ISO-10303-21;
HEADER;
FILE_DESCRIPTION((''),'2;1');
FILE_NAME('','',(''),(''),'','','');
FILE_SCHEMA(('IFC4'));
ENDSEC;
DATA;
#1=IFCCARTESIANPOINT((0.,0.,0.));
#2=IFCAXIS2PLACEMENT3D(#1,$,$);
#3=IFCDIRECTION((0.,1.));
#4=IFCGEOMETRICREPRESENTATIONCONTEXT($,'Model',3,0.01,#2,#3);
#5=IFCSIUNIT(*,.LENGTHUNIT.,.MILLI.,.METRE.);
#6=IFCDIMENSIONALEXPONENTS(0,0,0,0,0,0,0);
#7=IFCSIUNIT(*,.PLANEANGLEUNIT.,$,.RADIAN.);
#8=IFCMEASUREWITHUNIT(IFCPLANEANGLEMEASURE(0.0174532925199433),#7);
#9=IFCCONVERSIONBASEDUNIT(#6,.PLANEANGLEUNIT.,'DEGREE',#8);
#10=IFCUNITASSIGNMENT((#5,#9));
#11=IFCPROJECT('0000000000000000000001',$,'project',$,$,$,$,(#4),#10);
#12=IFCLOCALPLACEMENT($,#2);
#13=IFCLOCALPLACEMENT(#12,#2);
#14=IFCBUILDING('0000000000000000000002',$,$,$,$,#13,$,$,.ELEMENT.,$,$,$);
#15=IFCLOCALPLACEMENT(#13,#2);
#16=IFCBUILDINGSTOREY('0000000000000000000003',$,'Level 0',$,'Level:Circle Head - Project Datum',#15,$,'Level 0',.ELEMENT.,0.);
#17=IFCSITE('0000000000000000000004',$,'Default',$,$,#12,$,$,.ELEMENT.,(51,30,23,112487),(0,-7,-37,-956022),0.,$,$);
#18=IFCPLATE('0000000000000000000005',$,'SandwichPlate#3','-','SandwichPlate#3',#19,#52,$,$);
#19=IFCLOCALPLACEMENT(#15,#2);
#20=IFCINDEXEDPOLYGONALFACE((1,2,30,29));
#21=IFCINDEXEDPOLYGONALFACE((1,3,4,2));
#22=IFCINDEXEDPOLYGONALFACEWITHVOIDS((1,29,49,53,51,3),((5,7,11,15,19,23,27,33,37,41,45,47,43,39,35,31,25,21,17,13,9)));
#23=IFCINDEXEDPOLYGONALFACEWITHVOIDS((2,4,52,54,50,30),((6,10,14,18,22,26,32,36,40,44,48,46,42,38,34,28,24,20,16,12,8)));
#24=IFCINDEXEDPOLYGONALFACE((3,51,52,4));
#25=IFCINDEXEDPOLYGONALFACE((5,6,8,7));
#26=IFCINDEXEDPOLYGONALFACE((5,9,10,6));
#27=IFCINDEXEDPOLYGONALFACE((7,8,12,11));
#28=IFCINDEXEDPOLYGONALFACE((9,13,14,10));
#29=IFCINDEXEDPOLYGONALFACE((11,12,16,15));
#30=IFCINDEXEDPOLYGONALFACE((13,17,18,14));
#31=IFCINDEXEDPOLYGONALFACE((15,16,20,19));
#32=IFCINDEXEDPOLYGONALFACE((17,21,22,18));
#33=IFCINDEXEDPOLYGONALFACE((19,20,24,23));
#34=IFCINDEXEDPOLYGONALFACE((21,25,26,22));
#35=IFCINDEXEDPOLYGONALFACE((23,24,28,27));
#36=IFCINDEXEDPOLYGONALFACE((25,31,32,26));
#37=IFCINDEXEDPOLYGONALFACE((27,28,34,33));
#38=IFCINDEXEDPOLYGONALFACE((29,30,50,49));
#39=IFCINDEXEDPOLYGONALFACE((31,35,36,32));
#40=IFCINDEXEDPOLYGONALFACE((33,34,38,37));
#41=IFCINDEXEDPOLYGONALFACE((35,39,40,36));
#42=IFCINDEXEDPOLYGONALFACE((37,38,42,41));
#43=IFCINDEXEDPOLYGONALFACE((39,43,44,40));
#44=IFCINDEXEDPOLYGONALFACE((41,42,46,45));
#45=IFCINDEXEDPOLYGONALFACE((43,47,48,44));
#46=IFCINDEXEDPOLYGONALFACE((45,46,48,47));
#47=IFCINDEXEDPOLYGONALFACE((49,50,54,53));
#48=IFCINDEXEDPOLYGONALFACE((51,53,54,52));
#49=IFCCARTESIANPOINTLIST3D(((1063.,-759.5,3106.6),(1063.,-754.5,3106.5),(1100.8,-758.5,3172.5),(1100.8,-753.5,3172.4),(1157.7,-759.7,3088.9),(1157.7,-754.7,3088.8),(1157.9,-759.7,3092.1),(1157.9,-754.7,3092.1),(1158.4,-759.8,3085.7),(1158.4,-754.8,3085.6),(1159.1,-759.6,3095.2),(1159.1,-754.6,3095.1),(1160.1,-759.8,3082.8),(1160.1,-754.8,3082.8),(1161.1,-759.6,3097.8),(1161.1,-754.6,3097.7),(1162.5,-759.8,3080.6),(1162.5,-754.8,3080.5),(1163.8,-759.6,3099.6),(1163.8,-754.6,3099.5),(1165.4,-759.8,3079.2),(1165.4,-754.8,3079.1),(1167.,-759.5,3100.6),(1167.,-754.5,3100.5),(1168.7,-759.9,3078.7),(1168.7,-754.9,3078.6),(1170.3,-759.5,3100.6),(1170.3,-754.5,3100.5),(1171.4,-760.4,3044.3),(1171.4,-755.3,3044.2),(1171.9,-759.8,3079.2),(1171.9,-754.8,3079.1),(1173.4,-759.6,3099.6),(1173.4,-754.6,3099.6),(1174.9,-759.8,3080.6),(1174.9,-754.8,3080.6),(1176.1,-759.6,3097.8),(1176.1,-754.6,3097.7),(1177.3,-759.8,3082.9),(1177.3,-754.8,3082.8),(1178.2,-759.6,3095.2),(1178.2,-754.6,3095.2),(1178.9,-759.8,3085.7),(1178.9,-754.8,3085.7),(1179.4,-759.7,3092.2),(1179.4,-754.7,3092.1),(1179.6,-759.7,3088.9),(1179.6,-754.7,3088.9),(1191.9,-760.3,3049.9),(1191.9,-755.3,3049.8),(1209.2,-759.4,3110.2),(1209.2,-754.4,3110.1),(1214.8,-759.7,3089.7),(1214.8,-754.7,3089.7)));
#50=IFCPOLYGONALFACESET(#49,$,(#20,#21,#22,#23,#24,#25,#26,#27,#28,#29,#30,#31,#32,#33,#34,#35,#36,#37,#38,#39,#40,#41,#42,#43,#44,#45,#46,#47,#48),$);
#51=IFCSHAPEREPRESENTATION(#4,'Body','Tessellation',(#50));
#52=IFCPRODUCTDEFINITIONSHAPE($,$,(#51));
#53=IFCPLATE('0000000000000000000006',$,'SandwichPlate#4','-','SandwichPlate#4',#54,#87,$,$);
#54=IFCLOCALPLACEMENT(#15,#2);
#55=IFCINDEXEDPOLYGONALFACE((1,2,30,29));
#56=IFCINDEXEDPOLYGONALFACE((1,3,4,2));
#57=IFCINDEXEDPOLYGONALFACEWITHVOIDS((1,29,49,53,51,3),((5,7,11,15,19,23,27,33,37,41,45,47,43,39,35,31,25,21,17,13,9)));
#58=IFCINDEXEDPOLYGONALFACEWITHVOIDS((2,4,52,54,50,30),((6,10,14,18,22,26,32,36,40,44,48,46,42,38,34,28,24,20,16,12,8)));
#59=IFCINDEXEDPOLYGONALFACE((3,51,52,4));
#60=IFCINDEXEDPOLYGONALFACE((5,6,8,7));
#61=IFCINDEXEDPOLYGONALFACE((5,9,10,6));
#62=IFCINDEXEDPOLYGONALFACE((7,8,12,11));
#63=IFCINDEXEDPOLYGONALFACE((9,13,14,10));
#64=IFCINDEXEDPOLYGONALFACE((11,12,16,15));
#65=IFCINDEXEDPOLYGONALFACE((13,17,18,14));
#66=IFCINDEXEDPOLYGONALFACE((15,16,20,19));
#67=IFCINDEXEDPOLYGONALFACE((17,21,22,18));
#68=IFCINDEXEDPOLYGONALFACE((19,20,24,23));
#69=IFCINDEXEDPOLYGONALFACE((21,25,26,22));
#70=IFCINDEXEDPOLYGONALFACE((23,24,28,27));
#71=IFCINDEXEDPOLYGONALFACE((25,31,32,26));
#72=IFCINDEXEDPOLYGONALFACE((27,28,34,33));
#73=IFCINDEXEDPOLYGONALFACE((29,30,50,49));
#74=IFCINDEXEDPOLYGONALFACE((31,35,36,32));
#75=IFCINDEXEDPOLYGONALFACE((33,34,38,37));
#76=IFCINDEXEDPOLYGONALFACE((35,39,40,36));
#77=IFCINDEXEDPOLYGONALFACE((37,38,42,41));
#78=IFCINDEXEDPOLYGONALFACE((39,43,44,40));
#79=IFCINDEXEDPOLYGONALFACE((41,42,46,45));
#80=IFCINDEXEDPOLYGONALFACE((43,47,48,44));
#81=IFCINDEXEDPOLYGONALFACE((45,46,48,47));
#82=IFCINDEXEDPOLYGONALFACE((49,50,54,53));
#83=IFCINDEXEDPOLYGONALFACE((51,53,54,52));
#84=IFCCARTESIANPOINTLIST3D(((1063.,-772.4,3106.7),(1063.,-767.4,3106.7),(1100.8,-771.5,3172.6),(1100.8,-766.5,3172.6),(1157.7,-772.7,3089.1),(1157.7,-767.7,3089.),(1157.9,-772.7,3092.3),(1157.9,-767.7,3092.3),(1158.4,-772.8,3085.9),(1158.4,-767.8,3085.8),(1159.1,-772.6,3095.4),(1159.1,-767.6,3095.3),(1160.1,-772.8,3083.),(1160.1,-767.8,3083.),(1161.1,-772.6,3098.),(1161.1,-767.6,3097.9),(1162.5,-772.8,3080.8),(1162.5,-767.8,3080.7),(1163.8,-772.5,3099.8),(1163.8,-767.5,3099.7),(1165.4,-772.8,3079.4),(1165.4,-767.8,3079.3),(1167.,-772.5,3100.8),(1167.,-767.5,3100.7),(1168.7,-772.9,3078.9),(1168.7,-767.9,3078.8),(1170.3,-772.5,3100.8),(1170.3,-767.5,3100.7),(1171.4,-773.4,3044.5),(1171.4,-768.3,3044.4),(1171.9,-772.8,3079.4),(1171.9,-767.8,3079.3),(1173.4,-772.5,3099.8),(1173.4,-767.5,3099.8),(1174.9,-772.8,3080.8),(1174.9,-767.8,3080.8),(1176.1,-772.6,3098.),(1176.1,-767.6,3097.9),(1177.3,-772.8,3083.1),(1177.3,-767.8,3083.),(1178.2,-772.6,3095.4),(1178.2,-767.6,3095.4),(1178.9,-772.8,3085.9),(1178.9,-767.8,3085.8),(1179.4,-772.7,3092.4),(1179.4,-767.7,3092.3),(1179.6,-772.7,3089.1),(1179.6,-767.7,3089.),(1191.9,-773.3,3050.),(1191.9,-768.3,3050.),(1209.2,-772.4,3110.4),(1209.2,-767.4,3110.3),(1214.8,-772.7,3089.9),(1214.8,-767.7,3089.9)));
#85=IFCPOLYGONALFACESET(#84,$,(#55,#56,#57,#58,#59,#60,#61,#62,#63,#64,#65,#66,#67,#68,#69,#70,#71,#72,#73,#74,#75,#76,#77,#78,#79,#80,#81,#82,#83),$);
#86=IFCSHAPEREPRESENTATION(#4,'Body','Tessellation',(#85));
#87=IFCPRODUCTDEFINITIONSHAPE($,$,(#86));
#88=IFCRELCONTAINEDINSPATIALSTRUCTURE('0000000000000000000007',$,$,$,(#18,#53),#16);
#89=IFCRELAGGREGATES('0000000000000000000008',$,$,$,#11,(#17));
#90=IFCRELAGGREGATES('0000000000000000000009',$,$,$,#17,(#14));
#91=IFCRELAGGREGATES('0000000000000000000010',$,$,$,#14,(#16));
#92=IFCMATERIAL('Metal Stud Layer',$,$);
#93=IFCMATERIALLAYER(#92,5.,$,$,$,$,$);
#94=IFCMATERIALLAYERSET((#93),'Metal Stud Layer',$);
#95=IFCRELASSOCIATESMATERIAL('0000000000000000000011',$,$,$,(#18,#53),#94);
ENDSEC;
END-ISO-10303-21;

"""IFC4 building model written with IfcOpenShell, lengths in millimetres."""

from ifc_helpers import new_model, entity, si_unit, converted_unit, direction, frame, origin, origin_with_axes, origin_2d_with_axis, place, context, project, spatial, polyline, circle, outline, extrude, material, layer, layer_set, element, save


model = new_model("IFC4")

# Units and contexts
model_context = context("Model", 3, precision=0.01, world=origin(), true_north=direction((0.0, 1.0)))
ifc_project = project(units=[si_unit("LENGTHUNIT", "METRE", prefix="MILLI"), converted_unit("PLANEANGLEUNIT", "DEGREE", entity("IfcPlaneAngleMeasure", 0.0174532925199433), si_unit("PLANEANGLEUNIT", "RADIAN"), dimensions=[0, 0, 0, 0, 0, 0, 0])], contexts=[model_context])

# Site, building, storey
site_placement = place(None, origin())
site = spatial("IfcSite", under=ifc_project, at=site_placement, Name="Default", CompositionType="ELEMENT", RefLatitude=(51, 30, 23, 112487), RefLongitude=(0, -7, -37, -956022), RefElevation=0.0)
building_placement = place(site_placement, origin())
building = spatial("IfcBuilding", under=site, at=building_placement, CompositionType="ELEMENT")
storey_placement = place(building_placement, origin())
storey = spatial("IfcBuildingStorey", under=building, at=storey_placement, Name="Level 0", ObjectType="Level:Circle Head - Project Datum", LongName="Level 0", CompositionType="ELEMENT", Elevation=0.0)

# Plates, openings
ifc_material = material(Name="Metal Stud Layer")
ifc_layer_1 = layer(ifc_material, 5.0)
ifc_layer_set_1 = layer_set([ifc_layer_1], Name="Metal Stud Layer")
plate_1_placement = place(storey_placement, frame((1184.4, -755.5, 3036.8), z_axis=(0.0, -0.999896, 0.014432), x_axis=(0.497964, 0.012516, 0.867107)))
plate_1 = element("IfcPlate", 1, at=plate_1_placement, inside=storey, material=ifc_layer_set_1, Name="SandwichPlate#3", Description="-", ObjectType="SandwichPlate#3", context=model_context, shape_type="SweptSolid", body=[
    extrude(outline(polyline([(0.0, 0.0), (76.0, 0.0), (76.0, 140.0), (0.0, 140.0), (0.0, 0.0)])), origin_with_axes(), (0.0, 0.0, 1.0), 5.0),
])
opening_1_placement = place(plate_1_placement, frame((0.0, 0.0, 0.0), z_axis=(0.0, 0.0, 1.0), x_axis=(1.0, 0.0, 0.0)))
element("IfcOpeningElement", 2, at=opening_1_placement, cuts=plate_1, ObjectType="Opening", context=model_context, shape_type="SweptSolid", body=[
    extrude(outline(polyline([(0.0, 0.0), (15.0, 0.0), (0.0, 15.0), (0.0, 0.0)])), origin(), (0.0, 0.0, 1.0), 5.0),
])
opening_2_placement = place(plate_1_placement, frame((0.0, 0.0, 0.0), z_axis=(0.0, 0.0, 1.0), x_axis=(1.0, 0.0, 0.0)))
element("IfcOpeningElement", 3, at=opening_2_placement, cuts=plate_1, ObjectType="Opening", context=model_context, shape_type="SweptSolid", body=[
    extrude(outline(polyline([(76.0, 0.0), (76.0, 15.0), (61.0, 0.0), (76.0, 0.0)])), origin(), (0.0, 0.0, 1.0), 5.0),
])
opening_3_placement = place(plate_1_placement, frame((38.0, 40.0, -0.5), z_axis=(0.0, 0.0, 1.0), x_axis=(0.0, 1.0, 0.0)))
element("IfcOpeningElement", 4, at=opening_3_placement, cuts=plate_1, ObjectType="Opening", context=model_context, shape_type="SweptSolid", body=[
    extrude(circle(Radius=11.0, at=origin_2d_with_axis()), origin(), (0.0, 0.0, 1.0), 6.0),
])
plate_2_placement = place(storey_placement, frame((1184.4, -768.5, 3037.0), z_axis=(0.0, -0.999896, 0.014432), x_axis=(0.497964, 0.012516, 0.867107)))
plate_2 = element("IfcPlate", 5, at=plate_2_placement, inside=storey, material=ifc_layer_set_1, Name="SandwichPlate#4", Description="-", ObjectType="SandwichPlate#4", context=model_context, shape_type="SweptSolid", body=[
    extrude(outline(polyline([(0.0, 0.0), (76.0, 0.0), (76.0, 140.0), (0.0, 140.0), (0.0, 0.0)])), origin_with_axes(), (0.0, 0.0, 1.0), 5.0),
])
opening_4_placement = place(plate_2_placement, frame((0.0, 0.0, 0.0), z_axis=(0.0, 0.0, 1.0), x_axis=(1.0, 0.0, 0.0)))
element("IfcOpeningElement", 6, at=opening_4_placement, cuts=plate_2, ObjectType="Opening", context=model_context, shape_type="SweptSolid", body=[
    extrude(outline(polyline([(0.0, 0.0), (15.0, 0.0), (0.0, 15.0), (0.0, 0.0)])), origin(), (0.0, 0.0, 1.0), 5.0),
])
opening_5_placement = place(plate_2_placement, frame((0.0, 0.0, 0.0), z_axis=(0.0, 0.0, 1.0), x_axis=(1.0, 0.0, 0.0)))
element("IfcOpeningElement", 7, at=opening_5_placement, cuts=plate_2, ObjectType="Opening", context=model_context, shape_type="SweptSolid", body=[
    extrude(outline(polyline([(76.0, 0.0), (76.0, 15.0), (61.0, 0.0), (76.0, 0.0)])), origin(), (0.0, 0.0, 1.0), 5.0),
])
opening_6_placement = place(plate_2_placement, frame((38.0, 40.0, -0.5), z_axis=(0.0, 0.0, 1.0), x_axis=(0.0, 1.0, 0.0)))
element("IfcOpeningElement", 8, at=opening_6_placement, cuts=plate_2, ObjectType="Opening", context=model_context, shape_type="SweptSolid", body=[
    extrude(circle(Radius=11.0, at=origin_2d_with_axis()), origin(), (0.0, 0.0, 1.0), 6.0),
])

save(model, "model.ifc")
